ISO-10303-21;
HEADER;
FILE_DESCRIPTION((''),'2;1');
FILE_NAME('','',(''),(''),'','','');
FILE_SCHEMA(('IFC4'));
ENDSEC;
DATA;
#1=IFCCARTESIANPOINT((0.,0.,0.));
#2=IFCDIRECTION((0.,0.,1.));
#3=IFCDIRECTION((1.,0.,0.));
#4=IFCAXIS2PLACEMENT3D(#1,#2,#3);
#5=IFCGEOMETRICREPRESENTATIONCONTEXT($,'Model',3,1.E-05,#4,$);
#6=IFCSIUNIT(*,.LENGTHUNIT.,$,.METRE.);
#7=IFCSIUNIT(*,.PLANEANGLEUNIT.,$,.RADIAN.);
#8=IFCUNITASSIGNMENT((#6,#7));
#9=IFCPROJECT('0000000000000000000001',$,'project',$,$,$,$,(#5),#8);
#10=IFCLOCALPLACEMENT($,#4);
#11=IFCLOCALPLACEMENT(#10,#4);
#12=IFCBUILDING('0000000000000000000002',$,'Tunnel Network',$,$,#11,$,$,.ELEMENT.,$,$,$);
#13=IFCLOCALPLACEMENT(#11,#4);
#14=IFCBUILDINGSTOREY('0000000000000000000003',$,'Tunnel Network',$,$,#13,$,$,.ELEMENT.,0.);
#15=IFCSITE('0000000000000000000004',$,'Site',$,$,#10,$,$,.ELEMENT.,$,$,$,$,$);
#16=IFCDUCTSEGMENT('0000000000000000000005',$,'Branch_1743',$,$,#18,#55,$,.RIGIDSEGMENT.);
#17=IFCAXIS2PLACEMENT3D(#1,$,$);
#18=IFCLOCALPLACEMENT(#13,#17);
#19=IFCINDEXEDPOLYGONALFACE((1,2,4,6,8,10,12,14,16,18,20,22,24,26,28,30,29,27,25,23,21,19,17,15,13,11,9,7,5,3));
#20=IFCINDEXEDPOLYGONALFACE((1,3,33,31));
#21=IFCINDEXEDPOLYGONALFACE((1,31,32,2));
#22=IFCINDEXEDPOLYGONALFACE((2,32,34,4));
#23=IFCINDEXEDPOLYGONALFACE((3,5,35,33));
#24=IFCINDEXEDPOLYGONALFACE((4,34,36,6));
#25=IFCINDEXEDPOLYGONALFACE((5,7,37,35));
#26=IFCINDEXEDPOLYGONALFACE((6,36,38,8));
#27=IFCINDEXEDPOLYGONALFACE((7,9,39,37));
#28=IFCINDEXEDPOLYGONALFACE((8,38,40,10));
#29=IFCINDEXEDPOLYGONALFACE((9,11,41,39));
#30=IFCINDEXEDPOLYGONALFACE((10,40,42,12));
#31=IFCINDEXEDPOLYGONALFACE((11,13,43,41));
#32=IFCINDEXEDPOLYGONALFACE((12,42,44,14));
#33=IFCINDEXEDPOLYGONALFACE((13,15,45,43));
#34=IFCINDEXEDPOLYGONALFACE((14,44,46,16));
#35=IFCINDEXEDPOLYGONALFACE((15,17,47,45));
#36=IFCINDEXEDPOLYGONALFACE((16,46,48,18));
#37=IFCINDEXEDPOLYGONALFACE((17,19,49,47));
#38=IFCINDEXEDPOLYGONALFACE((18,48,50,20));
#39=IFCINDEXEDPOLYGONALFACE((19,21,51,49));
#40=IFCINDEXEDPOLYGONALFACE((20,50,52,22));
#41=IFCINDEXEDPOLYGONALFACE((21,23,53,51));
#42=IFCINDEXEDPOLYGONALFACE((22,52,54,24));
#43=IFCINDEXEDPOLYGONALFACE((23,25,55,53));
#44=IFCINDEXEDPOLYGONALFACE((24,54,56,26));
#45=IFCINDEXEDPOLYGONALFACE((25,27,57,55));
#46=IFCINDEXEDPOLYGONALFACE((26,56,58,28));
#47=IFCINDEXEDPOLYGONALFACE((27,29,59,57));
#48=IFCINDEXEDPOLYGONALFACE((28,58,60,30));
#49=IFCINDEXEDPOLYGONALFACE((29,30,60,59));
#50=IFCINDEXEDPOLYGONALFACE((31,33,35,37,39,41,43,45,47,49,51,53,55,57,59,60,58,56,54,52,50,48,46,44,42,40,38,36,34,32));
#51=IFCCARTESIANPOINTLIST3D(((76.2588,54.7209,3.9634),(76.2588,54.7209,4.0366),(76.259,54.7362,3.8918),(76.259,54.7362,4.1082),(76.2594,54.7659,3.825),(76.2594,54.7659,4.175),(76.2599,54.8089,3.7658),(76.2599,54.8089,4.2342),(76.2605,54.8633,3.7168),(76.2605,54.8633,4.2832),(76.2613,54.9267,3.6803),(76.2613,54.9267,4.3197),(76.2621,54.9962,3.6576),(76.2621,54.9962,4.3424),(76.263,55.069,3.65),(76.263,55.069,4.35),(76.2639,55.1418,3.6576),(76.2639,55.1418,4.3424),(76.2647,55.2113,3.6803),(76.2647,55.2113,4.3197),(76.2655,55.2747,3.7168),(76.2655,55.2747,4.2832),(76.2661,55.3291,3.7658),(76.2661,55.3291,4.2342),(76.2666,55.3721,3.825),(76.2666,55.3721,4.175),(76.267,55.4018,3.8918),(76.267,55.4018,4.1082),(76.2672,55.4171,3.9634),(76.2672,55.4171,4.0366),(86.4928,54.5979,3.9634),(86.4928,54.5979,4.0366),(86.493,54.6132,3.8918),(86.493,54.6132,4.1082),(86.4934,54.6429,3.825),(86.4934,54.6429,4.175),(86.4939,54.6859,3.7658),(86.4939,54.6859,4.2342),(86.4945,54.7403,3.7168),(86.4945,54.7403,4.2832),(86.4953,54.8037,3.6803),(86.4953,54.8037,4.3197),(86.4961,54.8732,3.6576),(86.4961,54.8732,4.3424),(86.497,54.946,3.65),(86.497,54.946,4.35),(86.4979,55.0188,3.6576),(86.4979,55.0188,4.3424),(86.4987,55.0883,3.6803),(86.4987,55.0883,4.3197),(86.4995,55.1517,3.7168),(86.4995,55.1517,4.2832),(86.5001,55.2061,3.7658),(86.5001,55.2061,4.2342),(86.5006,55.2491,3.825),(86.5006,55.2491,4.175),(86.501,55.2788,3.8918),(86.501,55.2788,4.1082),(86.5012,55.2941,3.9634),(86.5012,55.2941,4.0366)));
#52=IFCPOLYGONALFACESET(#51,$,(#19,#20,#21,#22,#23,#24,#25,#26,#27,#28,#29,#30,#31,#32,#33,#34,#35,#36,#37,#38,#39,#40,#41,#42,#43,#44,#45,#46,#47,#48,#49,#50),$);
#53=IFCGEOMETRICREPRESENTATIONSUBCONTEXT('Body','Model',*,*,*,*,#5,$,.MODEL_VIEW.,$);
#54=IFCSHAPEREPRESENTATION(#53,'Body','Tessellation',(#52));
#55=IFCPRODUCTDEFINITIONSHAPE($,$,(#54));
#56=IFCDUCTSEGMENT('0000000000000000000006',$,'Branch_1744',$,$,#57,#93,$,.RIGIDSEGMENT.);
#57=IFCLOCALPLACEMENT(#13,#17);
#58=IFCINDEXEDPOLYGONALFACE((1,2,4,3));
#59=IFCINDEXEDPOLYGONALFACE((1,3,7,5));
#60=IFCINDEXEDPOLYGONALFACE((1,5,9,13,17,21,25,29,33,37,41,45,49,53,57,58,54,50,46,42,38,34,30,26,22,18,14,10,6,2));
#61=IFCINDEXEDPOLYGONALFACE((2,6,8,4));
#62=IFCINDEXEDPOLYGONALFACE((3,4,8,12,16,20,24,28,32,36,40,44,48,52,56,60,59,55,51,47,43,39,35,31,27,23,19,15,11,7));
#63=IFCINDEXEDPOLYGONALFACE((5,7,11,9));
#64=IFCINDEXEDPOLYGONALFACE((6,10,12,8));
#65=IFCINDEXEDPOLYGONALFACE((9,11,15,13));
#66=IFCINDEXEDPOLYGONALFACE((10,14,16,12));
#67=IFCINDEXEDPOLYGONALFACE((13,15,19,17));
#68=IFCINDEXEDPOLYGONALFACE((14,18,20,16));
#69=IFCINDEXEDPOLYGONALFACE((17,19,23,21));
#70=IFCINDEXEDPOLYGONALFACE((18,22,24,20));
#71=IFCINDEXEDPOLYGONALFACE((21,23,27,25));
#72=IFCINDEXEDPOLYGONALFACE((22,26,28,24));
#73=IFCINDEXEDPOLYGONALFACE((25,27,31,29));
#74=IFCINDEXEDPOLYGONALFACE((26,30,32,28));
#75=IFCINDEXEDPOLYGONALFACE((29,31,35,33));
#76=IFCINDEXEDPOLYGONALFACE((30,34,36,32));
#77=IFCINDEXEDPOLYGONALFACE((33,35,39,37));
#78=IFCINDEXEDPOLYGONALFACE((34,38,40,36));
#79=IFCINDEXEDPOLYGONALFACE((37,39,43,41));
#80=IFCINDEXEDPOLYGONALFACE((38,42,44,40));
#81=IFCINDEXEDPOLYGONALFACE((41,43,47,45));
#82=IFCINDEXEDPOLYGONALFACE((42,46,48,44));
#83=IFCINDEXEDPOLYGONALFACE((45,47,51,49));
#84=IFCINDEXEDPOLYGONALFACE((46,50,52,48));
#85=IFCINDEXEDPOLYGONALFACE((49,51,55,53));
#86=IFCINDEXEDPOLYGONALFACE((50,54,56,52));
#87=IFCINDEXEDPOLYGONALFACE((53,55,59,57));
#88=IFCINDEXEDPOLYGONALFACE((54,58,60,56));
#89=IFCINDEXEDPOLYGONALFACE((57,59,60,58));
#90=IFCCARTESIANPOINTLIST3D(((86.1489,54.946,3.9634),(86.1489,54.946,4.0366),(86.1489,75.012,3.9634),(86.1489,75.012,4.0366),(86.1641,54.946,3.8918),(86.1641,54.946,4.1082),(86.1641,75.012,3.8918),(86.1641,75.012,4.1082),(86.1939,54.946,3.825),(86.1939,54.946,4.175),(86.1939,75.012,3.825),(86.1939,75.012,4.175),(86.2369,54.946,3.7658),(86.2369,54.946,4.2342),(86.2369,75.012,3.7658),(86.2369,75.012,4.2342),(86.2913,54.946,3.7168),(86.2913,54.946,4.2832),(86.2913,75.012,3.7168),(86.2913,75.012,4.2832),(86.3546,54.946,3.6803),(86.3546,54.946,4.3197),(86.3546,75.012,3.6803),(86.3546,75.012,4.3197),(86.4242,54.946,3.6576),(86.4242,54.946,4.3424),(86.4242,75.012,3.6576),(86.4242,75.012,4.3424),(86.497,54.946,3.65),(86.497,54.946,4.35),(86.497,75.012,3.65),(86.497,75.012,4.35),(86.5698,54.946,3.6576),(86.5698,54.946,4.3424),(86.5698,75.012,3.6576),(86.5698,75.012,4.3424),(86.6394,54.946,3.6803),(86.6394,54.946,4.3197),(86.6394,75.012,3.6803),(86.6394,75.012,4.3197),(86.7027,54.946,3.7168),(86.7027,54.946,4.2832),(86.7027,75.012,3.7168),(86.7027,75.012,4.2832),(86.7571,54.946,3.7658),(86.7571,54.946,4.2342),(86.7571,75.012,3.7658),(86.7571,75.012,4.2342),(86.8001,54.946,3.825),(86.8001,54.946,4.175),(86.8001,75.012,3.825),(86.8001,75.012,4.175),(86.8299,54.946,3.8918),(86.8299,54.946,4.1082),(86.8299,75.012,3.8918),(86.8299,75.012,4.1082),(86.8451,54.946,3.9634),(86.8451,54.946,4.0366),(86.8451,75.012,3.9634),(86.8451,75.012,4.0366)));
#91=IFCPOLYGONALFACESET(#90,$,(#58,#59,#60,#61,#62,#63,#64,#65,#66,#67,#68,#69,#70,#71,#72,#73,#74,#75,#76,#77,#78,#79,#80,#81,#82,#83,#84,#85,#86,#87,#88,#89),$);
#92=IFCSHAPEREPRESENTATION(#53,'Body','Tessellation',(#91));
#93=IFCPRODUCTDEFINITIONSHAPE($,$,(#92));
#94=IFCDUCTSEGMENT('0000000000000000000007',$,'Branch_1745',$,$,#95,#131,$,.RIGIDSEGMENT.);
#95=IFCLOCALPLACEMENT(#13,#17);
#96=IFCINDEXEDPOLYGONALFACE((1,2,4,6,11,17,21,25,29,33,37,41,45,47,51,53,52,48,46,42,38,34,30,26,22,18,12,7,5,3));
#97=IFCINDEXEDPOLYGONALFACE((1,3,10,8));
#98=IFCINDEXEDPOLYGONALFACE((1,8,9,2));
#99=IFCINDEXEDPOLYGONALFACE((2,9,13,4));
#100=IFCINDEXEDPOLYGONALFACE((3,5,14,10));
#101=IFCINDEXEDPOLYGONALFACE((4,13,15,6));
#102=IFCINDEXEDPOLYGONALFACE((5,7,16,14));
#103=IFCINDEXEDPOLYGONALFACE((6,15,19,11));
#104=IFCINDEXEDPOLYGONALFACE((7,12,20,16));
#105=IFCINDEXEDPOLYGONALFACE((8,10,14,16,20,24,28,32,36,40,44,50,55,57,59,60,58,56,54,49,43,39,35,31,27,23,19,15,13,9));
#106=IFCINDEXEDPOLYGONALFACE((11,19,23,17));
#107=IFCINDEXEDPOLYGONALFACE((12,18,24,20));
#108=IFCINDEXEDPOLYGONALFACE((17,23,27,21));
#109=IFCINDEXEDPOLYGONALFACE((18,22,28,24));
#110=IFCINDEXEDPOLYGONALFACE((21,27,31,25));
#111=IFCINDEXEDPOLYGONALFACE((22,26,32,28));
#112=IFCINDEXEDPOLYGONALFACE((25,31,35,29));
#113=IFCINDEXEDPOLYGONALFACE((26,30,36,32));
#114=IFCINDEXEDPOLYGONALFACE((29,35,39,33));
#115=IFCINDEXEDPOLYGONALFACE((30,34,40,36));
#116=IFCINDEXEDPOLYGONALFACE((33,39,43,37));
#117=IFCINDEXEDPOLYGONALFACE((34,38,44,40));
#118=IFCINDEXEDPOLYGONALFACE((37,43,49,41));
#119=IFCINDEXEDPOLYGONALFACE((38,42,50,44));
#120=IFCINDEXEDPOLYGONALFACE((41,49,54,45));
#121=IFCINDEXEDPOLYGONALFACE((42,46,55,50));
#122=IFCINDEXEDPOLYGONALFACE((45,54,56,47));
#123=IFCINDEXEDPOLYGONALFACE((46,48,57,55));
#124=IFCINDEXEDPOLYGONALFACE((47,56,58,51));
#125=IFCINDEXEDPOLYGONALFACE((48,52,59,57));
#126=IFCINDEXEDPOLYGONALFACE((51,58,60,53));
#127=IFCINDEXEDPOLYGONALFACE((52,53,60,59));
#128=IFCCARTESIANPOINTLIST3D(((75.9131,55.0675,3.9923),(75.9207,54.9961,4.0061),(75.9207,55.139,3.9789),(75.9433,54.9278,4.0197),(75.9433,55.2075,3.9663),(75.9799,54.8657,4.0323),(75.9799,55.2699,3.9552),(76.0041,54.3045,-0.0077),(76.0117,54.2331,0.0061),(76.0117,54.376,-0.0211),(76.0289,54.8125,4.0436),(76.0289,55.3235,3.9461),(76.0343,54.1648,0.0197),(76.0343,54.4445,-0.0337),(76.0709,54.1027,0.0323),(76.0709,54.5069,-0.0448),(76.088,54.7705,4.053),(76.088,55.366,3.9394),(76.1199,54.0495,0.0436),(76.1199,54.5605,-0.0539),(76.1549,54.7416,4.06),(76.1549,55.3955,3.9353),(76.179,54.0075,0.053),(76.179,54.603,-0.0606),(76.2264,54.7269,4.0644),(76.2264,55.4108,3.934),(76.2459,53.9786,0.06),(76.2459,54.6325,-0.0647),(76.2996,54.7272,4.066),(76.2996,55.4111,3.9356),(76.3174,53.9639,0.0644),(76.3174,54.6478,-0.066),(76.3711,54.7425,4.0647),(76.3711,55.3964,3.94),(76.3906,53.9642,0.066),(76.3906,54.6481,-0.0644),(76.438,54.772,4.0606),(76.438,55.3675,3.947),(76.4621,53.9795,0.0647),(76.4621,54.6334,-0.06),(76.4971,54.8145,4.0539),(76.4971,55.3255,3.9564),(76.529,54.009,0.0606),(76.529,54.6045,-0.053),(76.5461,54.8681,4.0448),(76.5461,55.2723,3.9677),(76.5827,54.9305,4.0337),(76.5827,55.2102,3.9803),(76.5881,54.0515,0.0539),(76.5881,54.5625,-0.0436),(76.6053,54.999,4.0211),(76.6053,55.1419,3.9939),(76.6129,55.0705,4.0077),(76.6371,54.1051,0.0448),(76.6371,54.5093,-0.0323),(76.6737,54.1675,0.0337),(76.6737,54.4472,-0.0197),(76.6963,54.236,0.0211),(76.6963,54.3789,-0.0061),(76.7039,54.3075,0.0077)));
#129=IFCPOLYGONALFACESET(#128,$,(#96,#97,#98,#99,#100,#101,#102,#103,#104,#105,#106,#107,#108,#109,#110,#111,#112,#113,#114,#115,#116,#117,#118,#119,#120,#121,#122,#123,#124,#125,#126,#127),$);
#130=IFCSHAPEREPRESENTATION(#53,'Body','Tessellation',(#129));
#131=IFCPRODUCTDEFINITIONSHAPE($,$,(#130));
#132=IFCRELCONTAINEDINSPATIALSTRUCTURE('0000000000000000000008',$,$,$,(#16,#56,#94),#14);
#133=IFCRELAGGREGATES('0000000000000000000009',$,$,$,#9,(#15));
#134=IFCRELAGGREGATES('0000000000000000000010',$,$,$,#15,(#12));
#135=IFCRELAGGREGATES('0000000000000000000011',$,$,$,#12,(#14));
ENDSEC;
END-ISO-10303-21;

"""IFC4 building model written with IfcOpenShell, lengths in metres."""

from ifc_helpers import new_model, si_unit, frame, origin_with_axes, origin_2d_with_axis, place, context, subcontext, project, spatial, circle, extrude, element, save


model = new_model("IFC4")

# Units and contexts
model_context = context("Model", 3, precision=1e-05, world=origin_with_axes())
body_context = subcontext(model_context, "Body", "Model", "MODEL_VIEW")
ifc_project = project(units=[si_unit("LENGTHUNIT", "METRE"), si_unit("PLANEANGLEUNIT", "RADIAN")], contexts=[model_context])

# Site, building, storey
site_placement = place(None, origin_with_axes())
site = spatial("IfcSite", under=ifc_project, at=site_placement, Name="Site", CompositionType="ELEMENT")
building_placement = place(site_placement, origin_with_axes())
building = spatial("IfcBuilding", under=site, at=building_placement, Name="Tunnel Network", CompositionType="ELEMENT")
storey_placement = place(building_placement, origin_with_axes())
storey = spatial("IfcBuildingStorey", under=building, at=storey_placement, Name="Tunnel Network", CompositionType="ELEMENT", Elevation=0.0)

# Duct segments
duct_segment_1_placement = place(storey_placement, frame((76.263, 55.069, 4.0), z_axis=(0.999928, -0.012018, 0.0), x_axis=(0.0, 0.0, 1.0)))
element("IfcDuctSegment", 1, at=duct_segment_1_placement, inside=storey, Name="Branch_1743", PredefinedType="RIGIDSEGMENT", context=body_context, shape_type="SweptSolid", body=[
    extrude(circle(Radius=0.35, at=origin_2d_with_axis()), origin_with_axes(), (0.0, 0.0, 1.0), 10.2347),
])
duct_segment_2_placement = place(storey_placement, frame((86.497, 54.946, 4.0), z_axis=(0.0, 1.0, 0.0), x_axis=(0.0, 0.0, 1.0)))
element("IfcDuctSegment", 2, at=duct_segment_2_placement, inside=storey, Name="Branch_1744", PredefinedType="RIGIDSEGMENT", context=body_context, shape_type="SweptSolid", body=[
    extrude(circle(Radius=0.35, at=origin_2d_with_axis()), origin_with_axes(), (0.0, 0.0, 1.0), 20.066),
])
duct_segment_3_placement = place(storey_placement, frame((76.354, 54.306, 0.0), z_axis=(-0.022342, 0.187324, 0.982044), x_axis=(0.99975, 0.004186, 0.021946)))
element("IfcDuctSegment", 3, at=duct_segment_3_placement, inside=storey, Name="Branch_1745", PredefinedType="RIGIDSEGMENT", context=body_context, shape_type="SweptSolid", body=[
    extrude(circle(Radius=0.35, at=origin_2d_with_axis()), origin_with_axes(), (0.0, 0.0, 1.0), 4.0731),
])

save(model, "model.ifc")
